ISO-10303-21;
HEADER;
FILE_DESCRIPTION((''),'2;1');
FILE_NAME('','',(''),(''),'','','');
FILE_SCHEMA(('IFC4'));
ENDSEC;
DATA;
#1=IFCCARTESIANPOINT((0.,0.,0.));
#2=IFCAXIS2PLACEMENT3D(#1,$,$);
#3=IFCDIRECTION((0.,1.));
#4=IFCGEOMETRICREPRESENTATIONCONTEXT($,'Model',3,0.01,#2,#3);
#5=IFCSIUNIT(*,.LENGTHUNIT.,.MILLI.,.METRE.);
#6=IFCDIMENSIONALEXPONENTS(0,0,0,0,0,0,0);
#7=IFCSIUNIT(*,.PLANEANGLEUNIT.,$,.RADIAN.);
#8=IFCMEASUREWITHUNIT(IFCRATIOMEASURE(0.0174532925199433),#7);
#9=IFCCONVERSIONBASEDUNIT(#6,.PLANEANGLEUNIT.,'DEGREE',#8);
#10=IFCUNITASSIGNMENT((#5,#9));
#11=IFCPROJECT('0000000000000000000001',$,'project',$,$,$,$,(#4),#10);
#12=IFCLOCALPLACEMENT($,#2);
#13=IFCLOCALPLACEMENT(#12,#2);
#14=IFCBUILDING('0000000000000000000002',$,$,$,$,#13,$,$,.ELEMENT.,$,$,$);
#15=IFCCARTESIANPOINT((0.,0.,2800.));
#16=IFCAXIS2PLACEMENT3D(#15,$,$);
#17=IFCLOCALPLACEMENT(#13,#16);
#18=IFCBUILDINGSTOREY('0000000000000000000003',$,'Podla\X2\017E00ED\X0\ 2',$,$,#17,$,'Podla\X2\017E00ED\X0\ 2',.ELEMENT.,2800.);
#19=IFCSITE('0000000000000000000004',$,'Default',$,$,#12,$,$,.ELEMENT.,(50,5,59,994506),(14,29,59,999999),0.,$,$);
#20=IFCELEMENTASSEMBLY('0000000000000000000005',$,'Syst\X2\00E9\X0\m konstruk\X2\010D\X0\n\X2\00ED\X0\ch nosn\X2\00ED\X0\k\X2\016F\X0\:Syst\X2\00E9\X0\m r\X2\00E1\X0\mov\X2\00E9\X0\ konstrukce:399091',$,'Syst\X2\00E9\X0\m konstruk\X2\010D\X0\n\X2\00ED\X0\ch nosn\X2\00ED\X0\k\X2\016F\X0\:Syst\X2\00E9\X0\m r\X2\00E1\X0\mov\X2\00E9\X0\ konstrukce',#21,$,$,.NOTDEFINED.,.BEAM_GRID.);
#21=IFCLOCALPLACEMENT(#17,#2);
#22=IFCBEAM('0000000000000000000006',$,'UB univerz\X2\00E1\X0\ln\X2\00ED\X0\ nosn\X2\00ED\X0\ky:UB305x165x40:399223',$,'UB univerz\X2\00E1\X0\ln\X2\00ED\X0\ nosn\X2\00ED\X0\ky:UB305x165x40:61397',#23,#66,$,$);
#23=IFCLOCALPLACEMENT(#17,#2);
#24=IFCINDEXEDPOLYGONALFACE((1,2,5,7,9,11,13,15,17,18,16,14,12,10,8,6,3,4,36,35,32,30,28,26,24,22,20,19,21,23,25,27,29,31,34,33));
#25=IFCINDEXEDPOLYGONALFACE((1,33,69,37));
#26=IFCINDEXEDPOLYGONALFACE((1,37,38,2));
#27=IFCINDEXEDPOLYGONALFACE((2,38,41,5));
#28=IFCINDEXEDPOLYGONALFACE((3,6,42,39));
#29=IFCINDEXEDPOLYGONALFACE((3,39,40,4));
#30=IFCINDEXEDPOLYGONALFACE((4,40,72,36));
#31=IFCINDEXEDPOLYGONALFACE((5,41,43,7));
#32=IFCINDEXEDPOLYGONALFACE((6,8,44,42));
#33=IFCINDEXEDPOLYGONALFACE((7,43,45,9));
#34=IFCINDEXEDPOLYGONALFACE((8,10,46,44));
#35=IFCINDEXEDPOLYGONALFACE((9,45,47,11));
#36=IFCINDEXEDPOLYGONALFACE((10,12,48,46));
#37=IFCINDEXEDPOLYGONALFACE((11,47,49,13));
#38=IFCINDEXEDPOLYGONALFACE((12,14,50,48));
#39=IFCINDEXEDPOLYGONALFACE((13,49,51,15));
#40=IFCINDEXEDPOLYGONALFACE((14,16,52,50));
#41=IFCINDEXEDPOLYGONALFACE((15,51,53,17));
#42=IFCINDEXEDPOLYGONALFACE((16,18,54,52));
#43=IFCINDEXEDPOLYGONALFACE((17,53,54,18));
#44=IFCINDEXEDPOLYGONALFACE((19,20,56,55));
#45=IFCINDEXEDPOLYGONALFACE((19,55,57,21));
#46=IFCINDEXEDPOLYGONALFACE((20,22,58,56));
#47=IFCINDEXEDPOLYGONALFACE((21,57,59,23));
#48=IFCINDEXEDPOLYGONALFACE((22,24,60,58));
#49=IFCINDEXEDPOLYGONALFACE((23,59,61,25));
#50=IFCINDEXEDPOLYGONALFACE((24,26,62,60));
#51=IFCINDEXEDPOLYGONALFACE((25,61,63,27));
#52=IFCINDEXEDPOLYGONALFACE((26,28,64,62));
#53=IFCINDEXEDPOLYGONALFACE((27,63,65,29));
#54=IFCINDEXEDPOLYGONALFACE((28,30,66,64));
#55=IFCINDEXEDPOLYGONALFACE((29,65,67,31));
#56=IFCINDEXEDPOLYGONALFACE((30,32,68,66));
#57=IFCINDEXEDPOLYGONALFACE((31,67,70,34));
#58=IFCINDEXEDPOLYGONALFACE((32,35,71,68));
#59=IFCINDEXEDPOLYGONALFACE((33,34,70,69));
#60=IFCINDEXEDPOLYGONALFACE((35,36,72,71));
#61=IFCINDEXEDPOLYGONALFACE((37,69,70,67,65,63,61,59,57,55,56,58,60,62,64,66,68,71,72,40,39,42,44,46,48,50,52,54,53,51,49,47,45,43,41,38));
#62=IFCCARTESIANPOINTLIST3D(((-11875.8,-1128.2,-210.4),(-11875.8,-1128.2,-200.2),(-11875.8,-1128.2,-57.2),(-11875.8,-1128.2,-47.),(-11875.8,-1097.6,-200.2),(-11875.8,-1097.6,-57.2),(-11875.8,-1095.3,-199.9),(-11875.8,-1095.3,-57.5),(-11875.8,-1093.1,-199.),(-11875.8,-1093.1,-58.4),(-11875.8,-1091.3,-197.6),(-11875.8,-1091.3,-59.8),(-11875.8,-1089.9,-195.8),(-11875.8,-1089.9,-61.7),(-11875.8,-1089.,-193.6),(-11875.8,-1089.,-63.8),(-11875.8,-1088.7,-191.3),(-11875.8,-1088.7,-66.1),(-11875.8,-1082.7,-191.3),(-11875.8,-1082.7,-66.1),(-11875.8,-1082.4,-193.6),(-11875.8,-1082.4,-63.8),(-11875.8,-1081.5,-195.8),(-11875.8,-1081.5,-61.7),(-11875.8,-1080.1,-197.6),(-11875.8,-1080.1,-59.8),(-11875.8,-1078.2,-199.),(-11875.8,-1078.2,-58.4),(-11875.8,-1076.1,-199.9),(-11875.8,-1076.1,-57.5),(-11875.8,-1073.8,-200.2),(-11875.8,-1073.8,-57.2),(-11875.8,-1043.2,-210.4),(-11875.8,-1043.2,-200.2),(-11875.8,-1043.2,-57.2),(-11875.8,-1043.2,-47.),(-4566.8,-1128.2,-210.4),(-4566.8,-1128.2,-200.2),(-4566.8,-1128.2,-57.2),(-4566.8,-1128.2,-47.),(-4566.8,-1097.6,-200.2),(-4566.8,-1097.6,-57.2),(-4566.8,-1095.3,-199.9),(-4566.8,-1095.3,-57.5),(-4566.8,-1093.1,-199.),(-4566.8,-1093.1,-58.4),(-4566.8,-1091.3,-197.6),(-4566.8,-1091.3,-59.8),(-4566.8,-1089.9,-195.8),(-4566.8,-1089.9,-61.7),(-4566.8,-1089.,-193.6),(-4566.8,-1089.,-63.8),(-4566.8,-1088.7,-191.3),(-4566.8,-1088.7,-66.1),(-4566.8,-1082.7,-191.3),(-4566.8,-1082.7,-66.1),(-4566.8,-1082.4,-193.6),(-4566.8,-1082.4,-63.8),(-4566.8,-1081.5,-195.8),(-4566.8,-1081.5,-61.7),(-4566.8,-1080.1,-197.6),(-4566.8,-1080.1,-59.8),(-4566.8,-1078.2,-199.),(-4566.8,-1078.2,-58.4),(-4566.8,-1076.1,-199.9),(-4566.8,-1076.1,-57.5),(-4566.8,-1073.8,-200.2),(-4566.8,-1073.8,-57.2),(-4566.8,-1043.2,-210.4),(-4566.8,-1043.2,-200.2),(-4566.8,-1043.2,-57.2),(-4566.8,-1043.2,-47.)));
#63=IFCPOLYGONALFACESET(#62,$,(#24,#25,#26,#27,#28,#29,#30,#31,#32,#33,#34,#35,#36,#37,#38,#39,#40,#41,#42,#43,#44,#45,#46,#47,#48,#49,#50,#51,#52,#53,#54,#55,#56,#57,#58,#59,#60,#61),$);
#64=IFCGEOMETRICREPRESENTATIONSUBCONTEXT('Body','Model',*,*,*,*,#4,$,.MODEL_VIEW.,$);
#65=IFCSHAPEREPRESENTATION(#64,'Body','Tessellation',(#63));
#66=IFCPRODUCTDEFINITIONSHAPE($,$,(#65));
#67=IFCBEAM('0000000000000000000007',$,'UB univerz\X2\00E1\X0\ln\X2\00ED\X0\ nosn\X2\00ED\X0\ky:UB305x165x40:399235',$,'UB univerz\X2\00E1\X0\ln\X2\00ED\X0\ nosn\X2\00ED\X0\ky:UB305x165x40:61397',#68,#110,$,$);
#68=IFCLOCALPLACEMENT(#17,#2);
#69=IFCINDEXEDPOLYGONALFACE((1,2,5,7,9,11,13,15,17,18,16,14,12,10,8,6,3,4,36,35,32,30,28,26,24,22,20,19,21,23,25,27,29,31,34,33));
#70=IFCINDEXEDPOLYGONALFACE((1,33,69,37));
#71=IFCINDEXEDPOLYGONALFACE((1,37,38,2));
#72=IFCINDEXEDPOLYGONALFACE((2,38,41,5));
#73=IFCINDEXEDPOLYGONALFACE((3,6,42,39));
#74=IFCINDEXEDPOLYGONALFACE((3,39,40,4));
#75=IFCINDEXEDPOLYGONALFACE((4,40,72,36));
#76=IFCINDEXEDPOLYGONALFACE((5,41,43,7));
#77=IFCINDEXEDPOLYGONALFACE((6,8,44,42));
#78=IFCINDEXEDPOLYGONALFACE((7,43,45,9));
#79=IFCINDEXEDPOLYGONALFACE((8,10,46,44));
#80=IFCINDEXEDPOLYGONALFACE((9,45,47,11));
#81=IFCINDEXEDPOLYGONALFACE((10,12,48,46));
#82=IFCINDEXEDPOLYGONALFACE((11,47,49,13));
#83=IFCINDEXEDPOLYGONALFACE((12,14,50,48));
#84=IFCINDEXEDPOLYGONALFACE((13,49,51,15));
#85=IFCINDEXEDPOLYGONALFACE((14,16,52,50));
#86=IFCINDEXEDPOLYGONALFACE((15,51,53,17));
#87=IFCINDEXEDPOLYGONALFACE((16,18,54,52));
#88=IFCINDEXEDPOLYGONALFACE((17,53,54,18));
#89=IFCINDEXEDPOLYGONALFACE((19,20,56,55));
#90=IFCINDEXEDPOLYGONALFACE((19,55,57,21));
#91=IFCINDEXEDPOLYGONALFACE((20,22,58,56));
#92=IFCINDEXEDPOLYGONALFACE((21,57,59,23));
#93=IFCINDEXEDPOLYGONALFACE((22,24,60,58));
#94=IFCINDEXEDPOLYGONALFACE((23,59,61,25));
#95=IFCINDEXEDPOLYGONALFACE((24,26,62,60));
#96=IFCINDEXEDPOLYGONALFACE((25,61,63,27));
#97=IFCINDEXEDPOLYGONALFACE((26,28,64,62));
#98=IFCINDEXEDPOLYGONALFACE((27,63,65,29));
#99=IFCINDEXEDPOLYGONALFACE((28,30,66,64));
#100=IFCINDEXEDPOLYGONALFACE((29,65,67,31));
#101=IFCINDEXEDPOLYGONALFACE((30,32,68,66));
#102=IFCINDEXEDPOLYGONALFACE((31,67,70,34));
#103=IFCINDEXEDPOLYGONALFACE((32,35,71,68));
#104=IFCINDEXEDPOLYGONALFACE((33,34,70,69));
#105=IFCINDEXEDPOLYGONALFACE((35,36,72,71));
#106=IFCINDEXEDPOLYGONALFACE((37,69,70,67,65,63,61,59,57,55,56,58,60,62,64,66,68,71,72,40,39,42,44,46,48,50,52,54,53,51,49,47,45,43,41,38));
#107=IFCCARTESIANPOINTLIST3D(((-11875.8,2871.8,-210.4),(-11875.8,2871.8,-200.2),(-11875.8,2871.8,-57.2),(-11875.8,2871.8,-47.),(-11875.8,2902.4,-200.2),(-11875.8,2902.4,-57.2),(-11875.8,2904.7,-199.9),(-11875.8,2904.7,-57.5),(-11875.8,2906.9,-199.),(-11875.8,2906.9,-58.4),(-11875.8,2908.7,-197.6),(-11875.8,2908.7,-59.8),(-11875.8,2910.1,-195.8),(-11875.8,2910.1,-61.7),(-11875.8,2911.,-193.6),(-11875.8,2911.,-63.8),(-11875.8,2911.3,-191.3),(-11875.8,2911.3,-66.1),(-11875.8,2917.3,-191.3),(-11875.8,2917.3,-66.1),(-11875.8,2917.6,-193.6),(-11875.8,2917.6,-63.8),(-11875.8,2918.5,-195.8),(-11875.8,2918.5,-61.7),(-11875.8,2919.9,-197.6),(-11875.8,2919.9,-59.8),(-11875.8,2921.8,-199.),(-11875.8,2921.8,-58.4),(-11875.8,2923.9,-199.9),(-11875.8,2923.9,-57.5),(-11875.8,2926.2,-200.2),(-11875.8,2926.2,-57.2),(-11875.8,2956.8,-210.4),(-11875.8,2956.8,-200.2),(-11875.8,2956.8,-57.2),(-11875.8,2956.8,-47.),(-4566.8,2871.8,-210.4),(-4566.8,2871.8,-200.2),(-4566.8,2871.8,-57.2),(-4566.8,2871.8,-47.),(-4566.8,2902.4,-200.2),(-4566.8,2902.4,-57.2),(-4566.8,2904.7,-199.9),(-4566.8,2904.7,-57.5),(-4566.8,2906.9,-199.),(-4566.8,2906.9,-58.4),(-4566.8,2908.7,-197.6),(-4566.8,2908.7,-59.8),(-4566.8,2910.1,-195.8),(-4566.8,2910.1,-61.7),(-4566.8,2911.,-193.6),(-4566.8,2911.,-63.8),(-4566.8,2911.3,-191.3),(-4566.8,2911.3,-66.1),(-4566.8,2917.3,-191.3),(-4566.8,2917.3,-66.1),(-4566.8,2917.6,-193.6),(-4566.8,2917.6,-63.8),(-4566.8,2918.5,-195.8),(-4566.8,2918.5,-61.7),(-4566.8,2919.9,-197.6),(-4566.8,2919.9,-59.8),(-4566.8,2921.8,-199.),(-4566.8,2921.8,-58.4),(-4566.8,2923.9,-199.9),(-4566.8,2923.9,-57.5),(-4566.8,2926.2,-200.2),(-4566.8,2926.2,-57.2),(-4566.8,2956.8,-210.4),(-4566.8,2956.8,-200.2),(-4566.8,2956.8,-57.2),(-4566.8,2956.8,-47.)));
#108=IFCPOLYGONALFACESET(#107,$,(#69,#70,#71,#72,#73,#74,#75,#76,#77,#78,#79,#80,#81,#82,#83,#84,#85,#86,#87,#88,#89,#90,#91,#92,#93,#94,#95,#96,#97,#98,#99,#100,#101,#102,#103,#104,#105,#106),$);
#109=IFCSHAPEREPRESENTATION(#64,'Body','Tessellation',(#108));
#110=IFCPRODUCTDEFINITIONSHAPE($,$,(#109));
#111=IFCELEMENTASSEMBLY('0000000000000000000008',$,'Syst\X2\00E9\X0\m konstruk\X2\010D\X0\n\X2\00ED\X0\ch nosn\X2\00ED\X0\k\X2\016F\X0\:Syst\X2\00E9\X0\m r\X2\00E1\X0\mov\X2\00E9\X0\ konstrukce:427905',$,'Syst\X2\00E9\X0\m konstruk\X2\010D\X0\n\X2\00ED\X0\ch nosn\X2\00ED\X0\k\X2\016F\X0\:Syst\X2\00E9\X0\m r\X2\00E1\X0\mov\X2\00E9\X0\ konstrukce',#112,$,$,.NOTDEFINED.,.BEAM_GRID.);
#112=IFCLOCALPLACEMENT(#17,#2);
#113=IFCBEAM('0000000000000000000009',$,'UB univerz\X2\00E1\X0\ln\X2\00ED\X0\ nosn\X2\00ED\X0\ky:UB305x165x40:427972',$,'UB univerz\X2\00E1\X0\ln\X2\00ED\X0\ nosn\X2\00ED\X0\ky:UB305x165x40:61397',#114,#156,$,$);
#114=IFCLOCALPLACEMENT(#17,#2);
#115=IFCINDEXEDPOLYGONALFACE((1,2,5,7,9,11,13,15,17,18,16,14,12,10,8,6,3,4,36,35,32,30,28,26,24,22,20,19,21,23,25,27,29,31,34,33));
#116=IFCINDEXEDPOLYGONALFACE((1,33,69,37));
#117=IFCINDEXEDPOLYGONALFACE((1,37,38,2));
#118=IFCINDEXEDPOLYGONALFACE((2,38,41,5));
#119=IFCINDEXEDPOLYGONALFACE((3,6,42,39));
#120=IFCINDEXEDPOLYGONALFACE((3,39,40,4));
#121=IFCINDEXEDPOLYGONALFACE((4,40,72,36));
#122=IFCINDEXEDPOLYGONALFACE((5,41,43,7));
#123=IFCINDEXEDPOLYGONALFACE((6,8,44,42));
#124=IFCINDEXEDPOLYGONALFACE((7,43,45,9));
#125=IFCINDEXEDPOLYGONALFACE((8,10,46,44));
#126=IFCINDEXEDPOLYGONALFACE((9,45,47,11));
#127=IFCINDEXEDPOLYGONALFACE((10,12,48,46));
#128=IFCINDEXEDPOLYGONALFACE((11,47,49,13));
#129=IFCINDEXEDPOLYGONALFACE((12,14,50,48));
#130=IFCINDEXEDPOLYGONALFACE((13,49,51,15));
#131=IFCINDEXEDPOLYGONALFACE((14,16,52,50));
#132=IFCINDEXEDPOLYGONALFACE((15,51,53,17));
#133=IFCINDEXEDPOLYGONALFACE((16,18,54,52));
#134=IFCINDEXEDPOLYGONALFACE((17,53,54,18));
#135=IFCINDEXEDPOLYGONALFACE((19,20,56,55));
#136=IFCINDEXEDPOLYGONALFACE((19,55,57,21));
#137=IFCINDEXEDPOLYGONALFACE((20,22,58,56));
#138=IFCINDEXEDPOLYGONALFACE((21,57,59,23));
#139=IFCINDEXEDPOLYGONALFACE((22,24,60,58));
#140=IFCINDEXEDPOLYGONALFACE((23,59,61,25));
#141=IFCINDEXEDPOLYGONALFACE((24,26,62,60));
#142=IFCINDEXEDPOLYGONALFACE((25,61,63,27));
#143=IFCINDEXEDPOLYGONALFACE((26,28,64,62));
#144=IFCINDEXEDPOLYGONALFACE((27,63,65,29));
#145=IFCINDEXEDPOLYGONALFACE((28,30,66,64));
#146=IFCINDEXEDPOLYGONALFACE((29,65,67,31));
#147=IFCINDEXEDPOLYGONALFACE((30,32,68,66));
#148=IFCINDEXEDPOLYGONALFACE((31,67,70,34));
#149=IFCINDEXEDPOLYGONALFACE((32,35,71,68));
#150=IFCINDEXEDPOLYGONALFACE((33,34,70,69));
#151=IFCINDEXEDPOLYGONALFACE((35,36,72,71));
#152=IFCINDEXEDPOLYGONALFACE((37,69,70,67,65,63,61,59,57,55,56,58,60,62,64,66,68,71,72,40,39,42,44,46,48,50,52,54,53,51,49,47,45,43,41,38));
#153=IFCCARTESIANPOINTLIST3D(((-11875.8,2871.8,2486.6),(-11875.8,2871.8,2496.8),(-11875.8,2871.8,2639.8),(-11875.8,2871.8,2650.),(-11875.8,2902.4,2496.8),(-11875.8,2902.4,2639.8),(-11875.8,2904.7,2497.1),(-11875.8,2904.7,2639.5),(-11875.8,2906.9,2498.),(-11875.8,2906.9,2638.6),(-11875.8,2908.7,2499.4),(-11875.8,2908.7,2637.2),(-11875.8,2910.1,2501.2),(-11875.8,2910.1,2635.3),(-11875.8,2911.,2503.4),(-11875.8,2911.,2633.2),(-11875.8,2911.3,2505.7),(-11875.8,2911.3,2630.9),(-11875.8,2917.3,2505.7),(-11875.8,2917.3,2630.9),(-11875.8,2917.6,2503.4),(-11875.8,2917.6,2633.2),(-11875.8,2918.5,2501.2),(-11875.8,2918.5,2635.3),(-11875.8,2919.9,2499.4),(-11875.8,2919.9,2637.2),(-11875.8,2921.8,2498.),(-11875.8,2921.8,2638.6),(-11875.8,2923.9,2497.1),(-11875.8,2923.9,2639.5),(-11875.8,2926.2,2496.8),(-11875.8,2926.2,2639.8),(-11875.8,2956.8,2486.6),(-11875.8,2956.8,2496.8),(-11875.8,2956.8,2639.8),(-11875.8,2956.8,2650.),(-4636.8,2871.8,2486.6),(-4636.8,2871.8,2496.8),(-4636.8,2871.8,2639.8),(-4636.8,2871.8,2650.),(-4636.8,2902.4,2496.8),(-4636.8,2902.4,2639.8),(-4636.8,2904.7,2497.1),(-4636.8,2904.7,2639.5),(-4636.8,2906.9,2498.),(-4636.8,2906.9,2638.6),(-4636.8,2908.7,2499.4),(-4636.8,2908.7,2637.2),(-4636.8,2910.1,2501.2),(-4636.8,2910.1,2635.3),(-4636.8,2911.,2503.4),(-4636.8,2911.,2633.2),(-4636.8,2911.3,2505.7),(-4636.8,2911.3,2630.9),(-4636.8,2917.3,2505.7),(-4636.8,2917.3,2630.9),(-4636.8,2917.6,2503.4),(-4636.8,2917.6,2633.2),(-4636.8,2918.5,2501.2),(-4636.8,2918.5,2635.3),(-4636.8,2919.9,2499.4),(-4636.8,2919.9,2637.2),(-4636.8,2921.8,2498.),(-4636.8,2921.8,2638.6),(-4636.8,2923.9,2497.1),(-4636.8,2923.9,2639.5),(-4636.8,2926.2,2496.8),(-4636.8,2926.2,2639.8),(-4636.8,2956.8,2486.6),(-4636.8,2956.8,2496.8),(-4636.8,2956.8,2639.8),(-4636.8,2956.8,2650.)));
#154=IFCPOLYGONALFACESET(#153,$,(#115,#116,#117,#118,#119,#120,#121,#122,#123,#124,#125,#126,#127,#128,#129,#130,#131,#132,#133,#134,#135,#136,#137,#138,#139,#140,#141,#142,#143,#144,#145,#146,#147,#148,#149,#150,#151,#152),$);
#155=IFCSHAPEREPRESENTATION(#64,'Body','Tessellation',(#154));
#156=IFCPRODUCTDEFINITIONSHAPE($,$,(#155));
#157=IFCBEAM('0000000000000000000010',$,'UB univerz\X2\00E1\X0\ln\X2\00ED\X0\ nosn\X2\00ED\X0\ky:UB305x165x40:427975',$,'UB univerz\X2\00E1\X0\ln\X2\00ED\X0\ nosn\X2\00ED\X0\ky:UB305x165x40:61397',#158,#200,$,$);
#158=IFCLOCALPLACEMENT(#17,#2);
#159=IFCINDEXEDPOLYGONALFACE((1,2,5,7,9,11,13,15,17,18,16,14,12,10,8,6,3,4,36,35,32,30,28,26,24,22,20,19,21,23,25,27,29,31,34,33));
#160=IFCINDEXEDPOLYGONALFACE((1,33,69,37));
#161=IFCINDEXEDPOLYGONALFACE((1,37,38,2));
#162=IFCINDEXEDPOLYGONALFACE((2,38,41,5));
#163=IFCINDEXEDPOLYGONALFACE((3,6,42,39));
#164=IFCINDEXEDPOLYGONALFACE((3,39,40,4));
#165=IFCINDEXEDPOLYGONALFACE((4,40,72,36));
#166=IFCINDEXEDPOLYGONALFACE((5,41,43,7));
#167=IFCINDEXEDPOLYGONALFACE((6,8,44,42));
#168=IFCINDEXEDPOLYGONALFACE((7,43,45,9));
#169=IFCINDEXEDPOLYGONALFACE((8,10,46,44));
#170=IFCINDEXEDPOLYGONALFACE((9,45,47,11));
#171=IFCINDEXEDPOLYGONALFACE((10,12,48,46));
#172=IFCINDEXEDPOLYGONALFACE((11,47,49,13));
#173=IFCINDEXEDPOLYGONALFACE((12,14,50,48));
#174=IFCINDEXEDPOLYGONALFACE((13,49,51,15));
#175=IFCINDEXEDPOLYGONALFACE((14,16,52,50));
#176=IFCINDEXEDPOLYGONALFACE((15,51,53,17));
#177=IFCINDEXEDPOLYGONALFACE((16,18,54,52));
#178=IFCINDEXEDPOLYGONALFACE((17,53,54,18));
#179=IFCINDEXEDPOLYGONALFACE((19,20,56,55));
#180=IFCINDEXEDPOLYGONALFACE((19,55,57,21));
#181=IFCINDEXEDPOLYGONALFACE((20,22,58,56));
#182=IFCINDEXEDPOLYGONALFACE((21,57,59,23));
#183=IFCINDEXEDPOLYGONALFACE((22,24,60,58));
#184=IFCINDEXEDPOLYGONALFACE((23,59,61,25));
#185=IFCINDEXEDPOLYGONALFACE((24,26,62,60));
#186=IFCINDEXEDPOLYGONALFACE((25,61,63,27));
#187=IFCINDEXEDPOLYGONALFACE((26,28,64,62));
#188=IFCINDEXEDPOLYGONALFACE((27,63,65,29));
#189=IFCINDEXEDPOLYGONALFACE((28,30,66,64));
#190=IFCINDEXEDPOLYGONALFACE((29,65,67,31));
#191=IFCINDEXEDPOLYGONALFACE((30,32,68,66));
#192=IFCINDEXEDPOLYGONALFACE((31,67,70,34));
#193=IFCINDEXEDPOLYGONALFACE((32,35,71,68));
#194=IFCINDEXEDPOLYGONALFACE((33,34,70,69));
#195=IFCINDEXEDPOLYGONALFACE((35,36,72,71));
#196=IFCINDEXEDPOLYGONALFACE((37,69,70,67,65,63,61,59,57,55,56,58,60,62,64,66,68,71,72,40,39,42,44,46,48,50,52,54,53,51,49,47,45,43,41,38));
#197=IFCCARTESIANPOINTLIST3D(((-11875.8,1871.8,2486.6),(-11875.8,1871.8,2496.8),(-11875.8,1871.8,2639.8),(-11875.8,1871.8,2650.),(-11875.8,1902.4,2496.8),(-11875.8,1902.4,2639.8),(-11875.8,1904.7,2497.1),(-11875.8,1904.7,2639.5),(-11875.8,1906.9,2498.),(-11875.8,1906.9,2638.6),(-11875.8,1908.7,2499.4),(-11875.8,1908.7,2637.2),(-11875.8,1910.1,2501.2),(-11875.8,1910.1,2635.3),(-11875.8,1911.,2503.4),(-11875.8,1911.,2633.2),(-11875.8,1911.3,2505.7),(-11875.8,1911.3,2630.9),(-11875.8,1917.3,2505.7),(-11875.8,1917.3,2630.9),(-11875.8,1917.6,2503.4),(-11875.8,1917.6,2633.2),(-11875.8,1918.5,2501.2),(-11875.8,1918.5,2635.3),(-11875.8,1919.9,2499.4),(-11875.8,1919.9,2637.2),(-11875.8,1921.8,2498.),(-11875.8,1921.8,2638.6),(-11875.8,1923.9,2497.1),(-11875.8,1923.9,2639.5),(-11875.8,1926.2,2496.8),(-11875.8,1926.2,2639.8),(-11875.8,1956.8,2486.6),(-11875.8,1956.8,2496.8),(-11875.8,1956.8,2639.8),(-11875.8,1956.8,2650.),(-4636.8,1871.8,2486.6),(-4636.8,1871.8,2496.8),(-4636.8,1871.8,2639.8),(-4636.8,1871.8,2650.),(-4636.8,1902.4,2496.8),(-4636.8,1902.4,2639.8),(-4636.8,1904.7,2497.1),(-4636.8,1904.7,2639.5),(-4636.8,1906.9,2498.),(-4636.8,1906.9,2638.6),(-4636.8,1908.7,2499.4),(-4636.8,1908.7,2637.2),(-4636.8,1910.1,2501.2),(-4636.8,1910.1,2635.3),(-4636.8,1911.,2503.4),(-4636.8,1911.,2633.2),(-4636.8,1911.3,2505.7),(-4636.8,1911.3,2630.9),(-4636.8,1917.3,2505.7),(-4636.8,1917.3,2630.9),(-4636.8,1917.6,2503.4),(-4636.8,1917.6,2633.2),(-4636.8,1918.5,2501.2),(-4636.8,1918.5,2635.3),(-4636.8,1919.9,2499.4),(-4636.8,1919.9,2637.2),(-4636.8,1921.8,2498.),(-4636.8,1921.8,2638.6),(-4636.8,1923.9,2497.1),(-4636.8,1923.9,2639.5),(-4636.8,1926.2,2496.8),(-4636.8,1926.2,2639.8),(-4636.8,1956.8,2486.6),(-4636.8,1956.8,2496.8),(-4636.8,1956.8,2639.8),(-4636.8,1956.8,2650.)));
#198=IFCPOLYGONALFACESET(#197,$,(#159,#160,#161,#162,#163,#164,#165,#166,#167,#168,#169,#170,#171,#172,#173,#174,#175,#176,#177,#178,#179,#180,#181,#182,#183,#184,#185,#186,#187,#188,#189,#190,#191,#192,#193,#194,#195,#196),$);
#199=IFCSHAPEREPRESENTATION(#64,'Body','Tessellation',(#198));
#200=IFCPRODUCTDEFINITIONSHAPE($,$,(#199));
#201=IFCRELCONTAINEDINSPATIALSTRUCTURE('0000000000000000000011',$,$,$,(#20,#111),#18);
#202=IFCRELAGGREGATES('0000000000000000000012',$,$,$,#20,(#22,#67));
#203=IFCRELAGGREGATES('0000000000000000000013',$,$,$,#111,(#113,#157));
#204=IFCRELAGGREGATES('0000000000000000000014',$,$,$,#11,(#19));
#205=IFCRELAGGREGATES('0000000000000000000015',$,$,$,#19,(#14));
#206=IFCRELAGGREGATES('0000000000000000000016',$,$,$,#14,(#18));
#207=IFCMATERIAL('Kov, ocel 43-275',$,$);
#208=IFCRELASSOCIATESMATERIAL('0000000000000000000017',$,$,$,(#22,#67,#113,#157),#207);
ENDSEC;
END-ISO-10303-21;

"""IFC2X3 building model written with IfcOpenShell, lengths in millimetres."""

from ifc_helpers import new_model, entity, si_unit, converted_unit, direction, frame, frame_2d, origin, place, context, subcontext, project, spatial, i_section, extrude, material, element, aggregate, save


model = new_model("IFC2X3")

# Units and contexts
model_context = context("Model", 3, precision=0.01, world=origin(), true_north=direction((0.0, 1.0)))
body_context = subcontext(model_context, "Body", "Model", "MODEL_VIEW")
ifc_project = project(units=[si_unit("LENGTHUNIT", "METRE", prefix="MILLI"), converted_unit("PLANEANGLEUNIT", "DEGREE", entity("IfcRatioMeasure", 0.0174532925199433), si_unit("PLANEANGLEUNIT", "RADIAN"), dimensions=[0, 0, 0, 0, 0, 0, 0])], contexts=[model_context])

# Site, building, storey
site_placement = place(None, origin())
site = spatial("IfcSite", under=ifc_project, at=site_placement, Name="Default", CompositionType="ELEMENT", RefLatitude=(50, 5, 59, 994506), RefLongitude=(14, 29, 59, 999999), RefElevation=0.0)
building_placement = place(site_placement, origin())
building = spatial("IfcBuilding", under=site, at=building_placement, CompositionType="ELEMENT")
storey_placement = place(building_placement, frame((0.0, 0.0, 2800.0)))
storey = spatial("IfcBuildingStorey", under=building, at=storey_placement, Name="Podlaží 2", LongName="Podlaží 2", CompositionType="ELEMENT", Elevation=2800.0)

# Element assemblies, beams
assembly_1_placement = place(storey_placement, origin())
assembly_1 = element("IfcElementAssembly", 1, at=assembly_1_placement, inside=storey, Name="Systém konstrukčních nosníků:Systém rámové konstrukce:399091", ObjectType="Systém konstrukčních nosníků:Systém rámové konstrukce", AssemblyPlace="NOTDEFINED", PredefinedType="BEAM_GRID")
ifc_material = material(Name="Kov, ocel 43-275")
beam_1_placement = place(assembly_1_placement, frame((-4566.8, -1085.7, -2800.0), z_axis=(0.0, 0.0, 1.0), x_axis=(-1.0, 0.0, 0.0)))
beam_1 = element("IfcBeam", 2, at=beam_1_placement, material=ifc_material, Name="UB univerzální nosníky:UB305x165x40:399223", ObjectType="UB univerzální nosníky:UB305x165x40:61397", context=body_context, shape_type="SweptSolid", body=[
    extrude(i_section(OverallWidth=85.0, OverallDepth=163.4, WebThickness=6.0, FlangeThickness=10.2, FilletRadius=8.9, at=frame_2d((0.0, 0.0), x_axis=(0.0, 1.0))), frame((0.0, 0.0, 2671.3), z_axis=(1.0, 0.0, 0.0), x_axis=(0.0, 0.0, -1.0)), (0.0, 0.0, 1.0), 7309.0),
])
beam_2_placement = place(assembly_1_placement, frame((-4566.8, 2914.3, -2800.0), z_axis=(0.0, 0.0, 1.0), x_axis=(-1.0, 0.0, 0.0)))
beam_2 = element("IfcBeam", 3, at=beam_2_placement, material=ifc_material, Name="UB univerzální nosníky:UB305x165x40:399235", ObjectType="UB univerzální nosníky:UB305x165x40:61397", context=body_context, shape_type="SweptSolid", body=[
    extrude(i_section(OverallWidth=85.0, OverallDepth=163.4, WebThickness=6.0, FlangeThickness=10.2, FilletRadius=8.9, at=frame_2d((0.0, 0.0), x_axis=(0.0, 1.0))), frame((0.0, 0.0, 2671.3), z_axis=(1.0, 0.0, 0.0), x_axis=(0.0, 0.0, -1.0)), (0.0, 0.0, 1.0), 7309.0),
])
aggregate(assembly_1, [beam_1, beam_2])
assembly_2_placement = place(storey_placement, origin())
assembly_2 = element("IfcElementAssembly", 4, at=assembly_2_placement, inside=storey, Name="Systém konstrukčních nosníků:Systém rámové konstrukce:427905", ObjectType="Systém konstrukčních nosníků:Systém rámové konstrukce", AssemblyPlace="NOTDEFINED", PredefinedType="BEAM_GRID")
beam_3_placement = place(assembly_2_placement, frame((-11875.8, 2914.3, 0.0)))
beam_3 = element("IfcBeam", 5, at=beam_3_placement, material=ifc_material, Name="UB univerzální nosníky:UB305x165x40:427972", ObjectType="UB univerzální nosníky:UB305x165x40:61397", context=body_context, shape_type="SweptSolid", body=[
    extrude(i_section(OverallWidth=85.0, OverallDepth=163.4, WebThickness=6.0, FlangeThickness=10.2, FilletRadius=8.9, at=frame_2d((0.0, 0.0), x_axis=(0.0, 1.0))), frame((0.0, 0.0, 2568.3), z_axis=(1.0, 0.0, 0.0), x_axis=(0.0, 0.0, -1.0)), (0.0, 0.0, 1.0), 7239.0),
])
beam_4_placement = place(assembly_2_placement, frame((-11875.8, 1914.3, 0.0)))
beam_4 = element("IfcBeam", 6, at=beam_4_placement, material=ifc_material, Name="UB univerzální nosníky:UB305x165x40:427975", ObjectType="UB univerzální nosníky:UB305x165x40:61397", context=body_context, shape_type="SweptSolid", body=[
    extrude(i_section(OverallWidth=85.0, OverallDepth=163.4, WebThickness=6.0, FlangeThickness=10.2, FilletRadius=8.9, at=frame_2d((0.0, 0.0), x_axis=(0.0, 1.0))), frame((0.0, 0.0, 2568.3), z_axis=(1.0, 0.0, 0.0), x_axis=(0.0, 0.0, -1.0)), (0.0, 0.0, 1.0), 7239.0),
])
aggregate(assembly_2, [beam_3, beam_4])

save(model, "model.ifc")
